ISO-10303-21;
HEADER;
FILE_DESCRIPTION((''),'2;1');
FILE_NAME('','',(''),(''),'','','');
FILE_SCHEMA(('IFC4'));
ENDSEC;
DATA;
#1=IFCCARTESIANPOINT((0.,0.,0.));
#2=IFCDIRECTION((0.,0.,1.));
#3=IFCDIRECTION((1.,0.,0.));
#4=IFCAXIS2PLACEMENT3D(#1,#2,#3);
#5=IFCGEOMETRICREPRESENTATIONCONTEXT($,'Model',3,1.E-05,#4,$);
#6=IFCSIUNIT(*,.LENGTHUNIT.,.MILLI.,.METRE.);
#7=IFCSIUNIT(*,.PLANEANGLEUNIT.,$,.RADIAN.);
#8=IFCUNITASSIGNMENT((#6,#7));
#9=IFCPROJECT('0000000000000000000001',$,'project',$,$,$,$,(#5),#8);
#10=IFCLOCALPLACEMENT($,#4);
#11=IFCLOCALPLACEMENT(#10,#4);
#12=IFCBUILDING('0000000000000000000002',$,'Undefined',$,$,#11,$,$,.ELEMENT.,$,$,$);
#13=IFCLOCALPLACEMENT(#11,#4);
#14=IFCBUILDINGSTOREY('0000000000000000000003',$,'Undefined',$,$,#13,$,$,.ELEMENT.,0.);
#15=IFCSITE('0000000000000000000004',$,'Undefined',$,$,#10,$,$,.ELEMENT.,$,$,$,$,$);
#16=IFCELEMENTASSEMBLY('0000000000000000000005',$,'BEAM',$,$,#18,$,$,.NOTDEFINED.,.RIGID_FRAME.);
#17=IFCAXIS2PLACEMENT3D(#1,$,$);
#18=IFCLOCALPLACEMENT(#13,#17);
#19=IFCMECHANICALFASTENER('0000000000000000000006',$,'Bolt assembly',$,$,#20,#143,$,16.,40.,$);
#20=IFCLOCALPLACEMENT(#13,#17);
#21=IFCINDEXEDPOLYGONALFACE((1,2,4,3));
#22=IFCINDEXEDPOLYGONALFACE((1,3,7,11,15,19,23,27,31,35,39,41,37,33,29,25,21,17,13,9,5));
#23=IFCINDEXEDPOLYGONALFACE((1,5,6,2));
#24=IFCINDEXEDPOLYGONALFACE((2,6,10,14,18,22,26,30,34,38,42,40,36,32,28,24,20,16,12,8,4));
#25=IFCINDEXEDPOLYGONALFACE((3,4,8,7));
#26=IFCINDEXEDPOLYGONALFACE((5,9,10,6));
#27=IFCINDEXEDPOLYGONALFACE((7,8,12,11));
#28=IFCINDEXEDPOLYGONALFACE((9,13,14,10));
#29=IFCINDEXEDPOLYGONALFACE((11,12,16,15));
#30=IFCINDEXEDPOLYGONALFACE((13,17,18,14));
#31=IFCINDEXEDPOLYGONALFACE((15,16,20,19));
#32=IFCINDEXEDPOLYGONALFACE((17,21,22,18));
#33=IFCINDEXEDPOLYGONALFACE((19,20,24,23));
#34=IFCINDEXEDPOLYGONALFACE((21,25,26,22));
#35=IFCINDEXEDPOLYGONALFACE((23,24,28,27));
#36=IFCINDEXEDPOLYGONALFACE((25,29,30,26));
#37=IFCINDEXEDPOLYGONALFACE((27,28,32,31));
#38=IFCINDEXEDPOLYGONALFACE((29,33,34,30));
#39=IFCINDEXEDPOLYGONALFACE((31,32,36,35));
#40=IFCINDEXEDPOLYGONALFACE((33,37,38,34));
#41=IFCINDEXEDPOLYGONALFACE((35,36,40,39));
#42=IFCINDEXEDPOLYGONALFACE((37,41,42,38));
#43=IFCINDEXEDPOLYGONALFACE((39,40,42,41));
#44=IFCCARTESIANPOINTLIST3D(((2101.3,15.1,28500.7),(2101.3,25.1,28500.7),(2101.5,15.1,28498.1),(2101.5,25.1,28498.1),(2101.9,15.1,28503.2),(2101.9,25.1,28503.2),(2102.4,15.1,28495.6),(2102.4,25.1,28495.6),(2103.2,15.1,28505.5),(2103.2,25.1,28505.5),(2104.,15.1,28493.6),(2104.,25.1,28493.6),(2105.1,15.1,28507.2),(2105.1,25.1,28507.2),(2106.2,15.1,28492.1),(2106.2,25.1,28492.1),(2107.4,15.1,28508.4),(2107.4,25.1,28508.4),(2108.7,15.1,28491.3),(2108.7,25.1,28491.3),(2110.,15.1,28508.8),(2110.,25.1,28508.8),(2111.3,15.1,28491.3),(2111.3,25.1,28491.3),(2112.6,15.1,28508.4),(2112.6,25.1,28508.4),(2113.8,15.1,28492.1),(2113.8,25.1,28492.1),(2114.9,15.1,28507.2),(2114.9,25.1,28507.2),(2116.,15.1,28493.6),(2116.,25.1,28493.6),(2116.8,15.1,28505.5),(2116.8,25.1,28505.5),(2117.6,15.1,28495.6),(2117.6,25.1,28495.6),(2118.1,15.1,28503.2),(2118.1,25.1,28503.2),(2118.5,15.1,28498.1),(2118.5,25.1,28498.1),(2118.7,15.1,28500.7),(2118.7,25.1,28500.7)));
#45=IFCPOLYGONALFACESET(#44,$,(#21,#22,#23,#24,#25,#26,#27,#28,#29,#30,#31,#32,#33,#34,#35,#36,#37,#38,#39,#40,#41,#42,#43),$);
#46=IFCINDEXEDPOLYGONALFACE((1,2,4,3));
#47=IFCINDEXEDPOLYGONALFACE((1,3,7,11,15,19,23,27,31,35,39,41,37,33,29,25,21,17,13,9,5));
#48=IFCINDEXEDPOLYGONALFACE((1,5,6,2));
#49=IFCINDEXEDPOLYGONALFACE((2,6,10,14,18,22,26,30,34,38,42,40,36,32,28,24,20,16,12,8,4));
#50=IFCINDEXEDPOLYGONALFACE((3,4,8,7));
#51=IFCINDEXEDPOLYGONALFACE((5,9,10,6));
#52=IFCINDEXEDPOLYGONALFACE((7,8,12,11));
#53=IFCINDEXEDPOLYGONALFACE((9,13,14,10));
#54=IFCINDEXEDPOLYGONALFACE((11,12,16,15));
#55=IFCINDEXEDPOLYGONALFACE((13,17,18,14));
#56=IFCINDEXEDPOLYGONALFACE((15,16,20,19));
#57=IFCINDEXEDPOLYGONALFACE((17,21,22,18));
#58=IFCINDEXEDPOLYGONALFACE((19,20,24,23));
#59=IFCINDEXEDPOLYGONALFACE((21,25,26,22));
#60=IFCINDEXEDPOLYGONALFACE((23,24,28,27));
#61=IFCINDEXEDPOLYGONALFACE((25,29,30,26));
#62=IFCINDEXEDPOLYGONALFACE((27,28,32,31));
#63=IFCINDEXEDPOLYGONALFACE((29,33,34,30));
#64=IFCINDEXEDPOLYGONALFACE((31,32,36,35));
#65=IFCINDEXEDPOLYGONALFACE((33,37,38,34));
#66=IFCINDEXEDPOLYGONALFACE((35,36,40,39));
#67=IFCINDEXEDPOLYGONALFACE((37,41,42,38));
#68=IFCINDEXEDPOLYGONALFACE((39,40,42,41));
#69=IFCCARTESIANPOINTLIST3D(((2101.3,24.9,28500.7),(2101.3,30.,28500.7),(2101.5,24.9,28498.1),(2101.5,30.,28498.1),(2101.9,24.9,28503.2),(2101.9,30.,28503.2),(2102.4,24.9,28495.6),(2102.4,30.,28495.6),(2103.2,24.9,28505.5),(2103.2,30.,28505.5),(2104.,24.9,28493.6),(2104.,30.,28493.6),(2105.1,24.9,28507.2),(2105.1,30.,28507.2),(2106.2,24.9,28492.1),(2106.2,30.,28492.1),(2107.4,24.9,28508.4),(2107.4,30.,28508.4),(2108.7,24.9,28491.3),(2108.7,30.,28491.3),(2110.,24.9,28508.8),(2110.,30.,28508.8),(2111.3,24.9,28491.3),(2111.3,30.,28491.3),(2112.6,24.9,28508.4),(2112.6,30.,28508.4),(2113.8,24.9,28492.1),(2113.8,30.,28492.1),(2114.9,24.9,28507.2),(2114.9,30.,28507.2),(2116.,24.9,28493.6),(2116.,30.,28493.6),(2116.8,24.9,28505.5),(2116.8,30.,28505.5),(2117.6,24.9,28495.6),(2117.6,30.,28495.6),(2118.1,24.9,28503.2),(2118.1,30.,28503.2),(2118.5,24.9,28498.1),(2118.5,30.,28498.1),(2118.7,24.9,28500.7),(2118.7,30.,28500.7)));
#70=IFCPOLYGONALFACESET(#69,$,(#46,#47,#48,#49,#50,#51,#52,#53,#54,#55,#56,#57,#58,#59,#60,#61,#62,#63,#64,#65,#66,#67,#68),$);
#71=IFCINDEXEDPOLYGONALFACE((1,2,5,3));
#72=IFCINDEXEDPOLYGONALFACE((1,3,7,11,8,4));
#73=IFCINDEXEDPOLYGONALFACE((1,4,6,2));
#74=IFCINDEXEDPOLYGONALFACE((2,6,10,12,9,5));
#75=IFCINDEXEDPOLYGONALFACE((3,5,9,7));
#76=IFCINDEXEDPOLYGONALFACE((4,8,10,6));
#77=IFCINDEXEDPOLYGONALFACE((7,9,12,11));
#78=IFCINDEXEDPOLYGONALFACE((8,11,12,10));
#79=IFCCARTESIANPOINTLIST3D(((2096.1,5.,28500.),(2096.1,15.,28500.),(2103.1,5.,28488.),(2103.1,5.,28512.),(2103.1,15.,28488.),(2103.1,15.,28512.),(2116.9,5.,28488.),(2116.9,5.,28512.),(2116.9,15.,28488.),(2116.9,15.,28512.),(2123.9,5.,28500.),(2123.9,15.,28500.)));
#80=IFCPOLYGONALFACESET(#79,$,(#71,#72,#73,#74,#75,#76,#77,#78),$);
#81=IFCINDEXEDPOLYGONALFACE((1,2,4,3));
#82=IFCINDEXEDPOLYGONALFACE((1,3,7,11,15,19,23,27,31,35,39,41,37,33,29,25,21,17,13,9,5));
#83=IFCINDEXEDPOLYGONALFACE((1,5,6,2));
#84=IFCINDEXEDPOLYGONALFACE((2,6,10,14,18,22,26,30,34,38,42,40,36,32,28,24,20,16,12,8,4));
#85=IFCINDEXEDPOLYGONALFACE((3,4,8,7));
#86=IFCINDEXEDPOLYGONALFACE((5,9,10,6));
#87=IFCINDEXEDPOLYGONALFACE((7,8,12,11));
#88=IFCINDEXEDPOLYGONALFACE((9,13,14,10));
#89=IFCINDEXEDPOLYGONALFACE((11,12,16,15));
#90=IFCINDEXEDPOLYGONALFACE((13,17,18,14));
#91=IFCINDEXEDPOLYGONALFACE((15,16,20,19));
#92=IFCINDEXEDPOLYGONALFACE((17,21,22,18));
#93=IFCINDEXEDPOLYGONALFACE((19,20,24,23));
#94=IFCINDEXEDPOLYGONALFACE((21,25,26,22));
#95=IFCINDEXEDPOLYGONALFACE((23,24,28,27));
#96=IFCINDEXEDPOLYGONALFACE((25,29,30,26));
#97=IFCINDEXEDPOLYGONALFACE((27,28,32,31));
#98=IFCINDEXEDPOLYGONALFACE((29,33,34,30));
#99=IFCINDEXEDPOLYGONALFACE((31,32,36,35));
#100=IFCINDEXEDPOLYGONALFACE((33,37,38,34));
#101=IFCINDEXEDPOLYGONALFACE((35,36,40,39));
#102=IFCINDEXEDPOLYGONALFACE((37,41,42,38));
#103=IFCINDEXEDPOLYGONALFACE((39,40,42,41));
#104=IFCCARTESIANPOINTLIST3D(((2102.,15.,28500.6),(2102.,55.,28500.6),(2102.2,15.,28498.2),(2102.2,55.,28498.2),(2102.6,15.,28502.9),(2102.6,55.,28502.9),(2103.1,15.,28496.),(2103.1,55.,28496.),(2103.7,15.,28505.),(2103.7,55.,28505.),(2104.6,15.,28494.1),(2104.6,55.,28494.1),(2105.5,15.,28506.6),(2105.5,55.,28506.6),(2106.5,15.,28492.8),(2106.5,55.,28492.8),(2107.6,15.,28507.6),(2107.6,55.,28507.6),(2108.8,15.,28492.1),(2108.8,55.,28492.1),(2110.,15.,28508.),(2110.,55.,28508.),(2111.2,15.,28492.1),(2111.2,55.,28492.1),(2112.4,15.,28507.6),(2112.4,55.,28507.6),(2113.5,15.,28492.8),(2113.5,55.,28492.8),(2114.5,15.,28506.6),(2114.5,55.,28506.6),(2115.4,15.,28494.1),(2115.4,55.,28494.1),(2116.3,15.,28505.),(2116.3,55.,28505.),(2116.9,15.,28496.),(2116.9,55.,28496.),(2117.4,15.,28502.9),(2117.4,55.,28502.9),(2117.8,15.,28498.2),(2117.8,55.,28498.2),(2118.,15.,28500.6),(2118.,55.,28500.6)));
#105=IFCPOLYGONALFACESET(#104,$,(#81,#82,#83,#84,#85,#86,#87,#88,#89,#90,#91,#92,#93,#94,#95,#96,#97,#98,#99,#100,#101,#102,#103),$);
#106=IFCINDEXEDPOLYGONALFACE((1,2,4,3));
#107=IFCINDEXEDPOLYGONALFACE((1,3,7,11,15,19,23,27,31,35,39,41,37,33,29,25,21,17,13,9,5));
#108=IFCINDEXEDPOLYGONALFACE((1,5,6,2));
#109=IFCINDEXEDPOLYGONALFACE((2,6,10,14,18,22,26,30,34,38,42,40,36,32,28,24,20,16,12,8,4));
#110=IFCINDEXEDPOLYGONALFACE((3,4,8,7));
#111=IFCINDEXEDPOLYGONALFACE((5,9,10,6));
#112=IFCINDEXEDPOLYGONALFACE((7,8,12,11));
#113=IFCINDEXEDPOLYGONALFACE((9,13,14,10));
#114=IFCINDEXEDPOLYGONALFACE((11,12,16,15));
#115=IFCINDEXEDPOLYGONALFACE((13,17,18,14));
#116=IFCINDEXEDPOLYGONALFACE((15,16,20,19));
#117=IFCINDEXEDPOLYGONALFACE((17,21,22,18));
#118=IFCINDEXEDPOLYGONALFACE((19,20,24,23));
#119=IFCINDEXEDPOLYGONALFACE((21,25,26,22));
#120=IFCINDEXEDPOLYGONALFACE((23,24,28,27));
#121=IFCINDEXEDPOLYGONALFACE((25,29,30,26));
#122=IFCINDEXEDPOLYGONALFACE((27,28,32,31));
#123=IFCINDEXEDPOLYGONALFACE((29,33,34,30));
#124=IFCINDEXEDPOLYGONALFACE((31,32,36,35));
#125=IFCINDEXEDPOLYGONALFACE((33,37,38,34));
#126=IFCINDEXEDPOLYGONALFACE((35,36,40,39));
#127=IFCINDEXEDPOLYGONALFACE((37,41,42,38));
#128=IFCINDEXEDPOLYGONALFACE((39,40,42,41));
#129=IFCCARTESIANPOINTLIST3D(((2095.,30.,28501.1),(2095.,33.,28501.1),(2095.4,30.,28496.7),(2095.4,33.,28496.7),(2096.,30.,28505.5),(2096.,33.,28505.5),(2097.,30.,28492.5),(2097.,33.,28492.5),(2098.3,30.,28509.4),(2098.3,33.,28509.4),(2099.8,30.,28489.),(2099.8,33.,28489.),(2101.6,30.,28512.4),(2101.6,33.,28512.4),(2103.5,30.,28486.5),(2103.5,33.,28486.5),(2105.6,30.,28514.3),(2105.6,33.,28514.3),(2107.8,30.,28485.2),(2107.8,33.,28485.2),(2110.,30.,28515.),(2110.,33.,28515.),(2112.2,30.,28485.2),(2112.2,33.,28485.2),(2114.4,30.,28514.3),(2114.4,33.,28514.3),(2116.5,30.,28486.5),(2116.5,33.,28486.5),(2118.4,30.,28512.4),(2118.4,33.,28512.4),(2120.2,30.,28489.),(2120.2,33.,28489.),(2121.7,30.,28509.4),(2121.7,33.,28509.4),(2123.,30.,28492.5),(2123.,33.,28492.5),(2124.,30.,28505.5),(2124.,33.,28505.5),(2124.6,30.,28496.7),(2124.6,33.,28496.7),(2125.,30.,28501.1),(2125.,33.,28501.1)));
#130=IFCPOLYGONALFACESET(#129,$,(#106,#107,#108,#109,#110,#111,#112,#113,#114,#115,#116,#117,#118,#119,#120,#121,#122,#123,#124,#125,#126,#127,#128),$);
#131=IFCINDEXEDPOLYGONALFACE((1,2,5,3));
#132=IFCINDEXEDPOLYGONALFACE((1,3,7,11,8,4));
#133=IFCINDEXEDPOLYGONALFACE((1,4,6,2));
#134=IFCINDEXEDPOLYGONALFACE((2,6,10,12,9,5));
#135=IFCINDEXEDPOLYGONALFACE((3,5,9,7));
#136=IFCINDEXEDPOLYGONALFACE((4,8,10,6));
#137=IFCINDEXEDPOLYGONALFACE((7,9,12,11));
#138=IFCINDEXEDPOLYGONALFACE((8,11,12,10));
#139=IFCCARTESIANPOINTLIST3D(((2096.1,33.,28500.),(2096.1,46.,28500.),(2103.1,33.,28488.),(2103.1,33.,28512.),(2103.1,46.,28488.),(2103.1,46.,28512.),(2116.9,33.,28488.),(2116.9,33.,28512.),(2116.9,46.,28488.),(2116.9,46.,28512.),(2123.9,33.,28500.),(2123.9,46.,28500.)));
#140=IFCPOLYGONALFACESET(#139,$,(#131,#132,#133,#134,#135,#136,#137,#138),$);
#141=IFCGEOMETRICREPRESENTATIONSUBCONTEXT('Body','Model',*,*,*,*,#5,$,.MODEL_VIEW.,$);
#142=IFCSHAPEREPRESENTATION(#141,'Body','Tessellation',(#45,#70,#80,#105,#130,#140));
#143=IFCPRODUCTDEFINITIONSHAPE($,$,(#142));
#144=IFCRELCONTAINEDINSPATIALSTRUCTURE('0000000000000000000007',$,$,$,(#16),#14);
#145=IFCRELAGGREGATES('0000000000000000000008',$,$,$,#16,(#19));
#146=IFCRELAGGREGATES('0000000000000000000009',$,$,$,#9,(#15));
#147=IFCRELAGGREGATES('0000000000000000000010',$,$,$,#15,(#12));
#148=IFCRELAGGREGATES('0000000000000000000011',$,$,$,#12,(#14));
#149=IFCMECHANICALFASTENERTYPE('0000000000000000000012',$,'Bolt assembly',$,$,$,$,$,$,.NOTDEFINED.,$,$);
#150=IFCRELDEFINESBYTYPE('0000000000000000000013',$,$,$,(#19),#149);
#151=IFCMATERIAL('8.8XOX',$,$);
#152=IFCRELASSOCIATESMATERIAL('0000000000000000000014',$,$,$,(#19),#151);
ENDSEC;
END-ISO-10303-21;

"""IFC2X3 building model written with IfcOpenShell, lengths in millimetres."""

from ifc_helpers import new_model, si_unit, frame, origin_with_axes, origin_2d_with_axis, place, context, subcontext, project, spatial, polyline, circle, outline, extrude, source, transform, mapped, material, type_object, element, aggregate, save


model = new_model("IFC2X3")

# Units and contexts
model_context = context("Model", 3, precision=1e-05, world=origin_with_axes())
body_context = subcontext(model_context, "Body", "Model", "MODEL_VIEW")
ifc_project = project(units=[si_unit("LENGTHUNIT", "METRE", prefix="MILLI"), si_unit("PLANEANGLEUNIT", "RADIAN")], contexts=[model_context])

# Site, building, storey
site_placement = place(None, origin_with_axes())
site = spatial("IfcSite", under=ifc_project, at=site_placement, Name="Undefined", CompositionType="ELEMENT")
building_placement = place(site_placement, origin_with_axes())
building = spatial("IfcBuilding", under=site, at=building_placement, Name="Undefined", CompositionType="ELEMENT")
storey_placement = place(building_placement, origin_with_axes())
storey = spatial("IfcBuildingStorey", under=building, at=storey_placement, Name="Undefined", CompositionType="ELEMENT", Elevation=0.0)

# Element assembly
assembly_1_placement = place(storey_placement, origin_with_axes())
assembly_1 = element("IfcElementAssembly", 1, at=assembly_1_placement, inside=storey, Name="BEAM", AssemblyPlace="NOTDEFINED", PredefinedType="RIGID_FRAME")

# Mechanical fastener
ifc_material_1 = material(Name="8.8XOX")
mechanical_fastener_type = type_object("IfcMechanicalFastenerType", Name="Bolt assembly")
shared_shape_1 = source(origin_with_axes(), body_context, "Body", "SweptSolid", [
    extrude(circle(Radius=8.8, at=origin_2d_with_axis()), frame((0.0, 15.1, 0.0), z_axis=(0.0, 1.0, 0.0), x_axis=(1.0, 0.0, 0.0)), (0.0, 0.0, 1.0), 10.0),
    extrude(circle(Radius=8.8, at=origin_2d_with_axis()), frame((0.0, 24.9, 0.0), z_axis=(0.0, 1.0, 0.0), x_axis=(1.0, 0.0, 0.0)), (0.0, 0.0, 1.0), 5.1),
    extrude(outline(polyline([(12.0, -6.9), (12.0, 6.9), (0.0, 13.9), (-12.0, 6.9), (-12.0, -6.9), (0.0, -13.9), (12.0, -6.9)])), frame((0.0, 5.0, 0.0), z_axis=(0.0, 1.0, 0.0), x_axis=(1.0, 0.0, 0.0)), (0.0, 0.0, 1.0), 10.0),
    extrude(circle(Radius=8.0, at=origin_2d_with_axis()), frame((0.0, 15.0, 0.0), z_axis=(0.0, 1.0, 0.0), x_axis=(1.0, 0.0, 0.0)), (0.0, 0.0, 1.0), 40.0),
    extrude(circle(Radius=15.0, at=origin_2d_with_axis()), frame((0.0, 30.0, 0.0), z_axis=(0.0, 1.0, 0.0), x_axis=(1.0, 0.0, 0.0)), (0.0, 0.0, 1.0), 3.0),
    extrude(outline(polyline([(12.0, -6.9), (12.0, 6.9), (0.0, 13.9), (-12.0, 6.9), (-12.0, -6.9), (0.0, -13.9), (12.0, -6.9)])), frame((0.0, 33.0, 0.0), z_axis=(0.0, 1.0, 0.0), x_axis=(1.0, 0.0, 0.0)), (0.0, 0.0, 1.0), 13.0),
])
mechanical_fastener_1_placement = place(assembly_1_placement, frame((2110.0, 0.0, 28500.0), z_axis=(-1.0, 0.0, 0.0), x_axis=(0.0, 0.0, 1.0)))
mechanical_fastener_1 = element("IfcMechanicalFastener", 2, at=mechanical_fastener_1_placement, type_object=mechanical_fastener_type, material=ifc_material_1, Name="Bolt assembly", NominalDiameter=16.0, NominalLength=40.0, context=body_context, shape_type="MappedRepresentation", body=[
    mapped(shared_shape_1, transform((0.0, 0.0, 0.0))),
])
aggregate(assembly_1, [mechanical_fastener_1])

save(model, "model.ifc")
